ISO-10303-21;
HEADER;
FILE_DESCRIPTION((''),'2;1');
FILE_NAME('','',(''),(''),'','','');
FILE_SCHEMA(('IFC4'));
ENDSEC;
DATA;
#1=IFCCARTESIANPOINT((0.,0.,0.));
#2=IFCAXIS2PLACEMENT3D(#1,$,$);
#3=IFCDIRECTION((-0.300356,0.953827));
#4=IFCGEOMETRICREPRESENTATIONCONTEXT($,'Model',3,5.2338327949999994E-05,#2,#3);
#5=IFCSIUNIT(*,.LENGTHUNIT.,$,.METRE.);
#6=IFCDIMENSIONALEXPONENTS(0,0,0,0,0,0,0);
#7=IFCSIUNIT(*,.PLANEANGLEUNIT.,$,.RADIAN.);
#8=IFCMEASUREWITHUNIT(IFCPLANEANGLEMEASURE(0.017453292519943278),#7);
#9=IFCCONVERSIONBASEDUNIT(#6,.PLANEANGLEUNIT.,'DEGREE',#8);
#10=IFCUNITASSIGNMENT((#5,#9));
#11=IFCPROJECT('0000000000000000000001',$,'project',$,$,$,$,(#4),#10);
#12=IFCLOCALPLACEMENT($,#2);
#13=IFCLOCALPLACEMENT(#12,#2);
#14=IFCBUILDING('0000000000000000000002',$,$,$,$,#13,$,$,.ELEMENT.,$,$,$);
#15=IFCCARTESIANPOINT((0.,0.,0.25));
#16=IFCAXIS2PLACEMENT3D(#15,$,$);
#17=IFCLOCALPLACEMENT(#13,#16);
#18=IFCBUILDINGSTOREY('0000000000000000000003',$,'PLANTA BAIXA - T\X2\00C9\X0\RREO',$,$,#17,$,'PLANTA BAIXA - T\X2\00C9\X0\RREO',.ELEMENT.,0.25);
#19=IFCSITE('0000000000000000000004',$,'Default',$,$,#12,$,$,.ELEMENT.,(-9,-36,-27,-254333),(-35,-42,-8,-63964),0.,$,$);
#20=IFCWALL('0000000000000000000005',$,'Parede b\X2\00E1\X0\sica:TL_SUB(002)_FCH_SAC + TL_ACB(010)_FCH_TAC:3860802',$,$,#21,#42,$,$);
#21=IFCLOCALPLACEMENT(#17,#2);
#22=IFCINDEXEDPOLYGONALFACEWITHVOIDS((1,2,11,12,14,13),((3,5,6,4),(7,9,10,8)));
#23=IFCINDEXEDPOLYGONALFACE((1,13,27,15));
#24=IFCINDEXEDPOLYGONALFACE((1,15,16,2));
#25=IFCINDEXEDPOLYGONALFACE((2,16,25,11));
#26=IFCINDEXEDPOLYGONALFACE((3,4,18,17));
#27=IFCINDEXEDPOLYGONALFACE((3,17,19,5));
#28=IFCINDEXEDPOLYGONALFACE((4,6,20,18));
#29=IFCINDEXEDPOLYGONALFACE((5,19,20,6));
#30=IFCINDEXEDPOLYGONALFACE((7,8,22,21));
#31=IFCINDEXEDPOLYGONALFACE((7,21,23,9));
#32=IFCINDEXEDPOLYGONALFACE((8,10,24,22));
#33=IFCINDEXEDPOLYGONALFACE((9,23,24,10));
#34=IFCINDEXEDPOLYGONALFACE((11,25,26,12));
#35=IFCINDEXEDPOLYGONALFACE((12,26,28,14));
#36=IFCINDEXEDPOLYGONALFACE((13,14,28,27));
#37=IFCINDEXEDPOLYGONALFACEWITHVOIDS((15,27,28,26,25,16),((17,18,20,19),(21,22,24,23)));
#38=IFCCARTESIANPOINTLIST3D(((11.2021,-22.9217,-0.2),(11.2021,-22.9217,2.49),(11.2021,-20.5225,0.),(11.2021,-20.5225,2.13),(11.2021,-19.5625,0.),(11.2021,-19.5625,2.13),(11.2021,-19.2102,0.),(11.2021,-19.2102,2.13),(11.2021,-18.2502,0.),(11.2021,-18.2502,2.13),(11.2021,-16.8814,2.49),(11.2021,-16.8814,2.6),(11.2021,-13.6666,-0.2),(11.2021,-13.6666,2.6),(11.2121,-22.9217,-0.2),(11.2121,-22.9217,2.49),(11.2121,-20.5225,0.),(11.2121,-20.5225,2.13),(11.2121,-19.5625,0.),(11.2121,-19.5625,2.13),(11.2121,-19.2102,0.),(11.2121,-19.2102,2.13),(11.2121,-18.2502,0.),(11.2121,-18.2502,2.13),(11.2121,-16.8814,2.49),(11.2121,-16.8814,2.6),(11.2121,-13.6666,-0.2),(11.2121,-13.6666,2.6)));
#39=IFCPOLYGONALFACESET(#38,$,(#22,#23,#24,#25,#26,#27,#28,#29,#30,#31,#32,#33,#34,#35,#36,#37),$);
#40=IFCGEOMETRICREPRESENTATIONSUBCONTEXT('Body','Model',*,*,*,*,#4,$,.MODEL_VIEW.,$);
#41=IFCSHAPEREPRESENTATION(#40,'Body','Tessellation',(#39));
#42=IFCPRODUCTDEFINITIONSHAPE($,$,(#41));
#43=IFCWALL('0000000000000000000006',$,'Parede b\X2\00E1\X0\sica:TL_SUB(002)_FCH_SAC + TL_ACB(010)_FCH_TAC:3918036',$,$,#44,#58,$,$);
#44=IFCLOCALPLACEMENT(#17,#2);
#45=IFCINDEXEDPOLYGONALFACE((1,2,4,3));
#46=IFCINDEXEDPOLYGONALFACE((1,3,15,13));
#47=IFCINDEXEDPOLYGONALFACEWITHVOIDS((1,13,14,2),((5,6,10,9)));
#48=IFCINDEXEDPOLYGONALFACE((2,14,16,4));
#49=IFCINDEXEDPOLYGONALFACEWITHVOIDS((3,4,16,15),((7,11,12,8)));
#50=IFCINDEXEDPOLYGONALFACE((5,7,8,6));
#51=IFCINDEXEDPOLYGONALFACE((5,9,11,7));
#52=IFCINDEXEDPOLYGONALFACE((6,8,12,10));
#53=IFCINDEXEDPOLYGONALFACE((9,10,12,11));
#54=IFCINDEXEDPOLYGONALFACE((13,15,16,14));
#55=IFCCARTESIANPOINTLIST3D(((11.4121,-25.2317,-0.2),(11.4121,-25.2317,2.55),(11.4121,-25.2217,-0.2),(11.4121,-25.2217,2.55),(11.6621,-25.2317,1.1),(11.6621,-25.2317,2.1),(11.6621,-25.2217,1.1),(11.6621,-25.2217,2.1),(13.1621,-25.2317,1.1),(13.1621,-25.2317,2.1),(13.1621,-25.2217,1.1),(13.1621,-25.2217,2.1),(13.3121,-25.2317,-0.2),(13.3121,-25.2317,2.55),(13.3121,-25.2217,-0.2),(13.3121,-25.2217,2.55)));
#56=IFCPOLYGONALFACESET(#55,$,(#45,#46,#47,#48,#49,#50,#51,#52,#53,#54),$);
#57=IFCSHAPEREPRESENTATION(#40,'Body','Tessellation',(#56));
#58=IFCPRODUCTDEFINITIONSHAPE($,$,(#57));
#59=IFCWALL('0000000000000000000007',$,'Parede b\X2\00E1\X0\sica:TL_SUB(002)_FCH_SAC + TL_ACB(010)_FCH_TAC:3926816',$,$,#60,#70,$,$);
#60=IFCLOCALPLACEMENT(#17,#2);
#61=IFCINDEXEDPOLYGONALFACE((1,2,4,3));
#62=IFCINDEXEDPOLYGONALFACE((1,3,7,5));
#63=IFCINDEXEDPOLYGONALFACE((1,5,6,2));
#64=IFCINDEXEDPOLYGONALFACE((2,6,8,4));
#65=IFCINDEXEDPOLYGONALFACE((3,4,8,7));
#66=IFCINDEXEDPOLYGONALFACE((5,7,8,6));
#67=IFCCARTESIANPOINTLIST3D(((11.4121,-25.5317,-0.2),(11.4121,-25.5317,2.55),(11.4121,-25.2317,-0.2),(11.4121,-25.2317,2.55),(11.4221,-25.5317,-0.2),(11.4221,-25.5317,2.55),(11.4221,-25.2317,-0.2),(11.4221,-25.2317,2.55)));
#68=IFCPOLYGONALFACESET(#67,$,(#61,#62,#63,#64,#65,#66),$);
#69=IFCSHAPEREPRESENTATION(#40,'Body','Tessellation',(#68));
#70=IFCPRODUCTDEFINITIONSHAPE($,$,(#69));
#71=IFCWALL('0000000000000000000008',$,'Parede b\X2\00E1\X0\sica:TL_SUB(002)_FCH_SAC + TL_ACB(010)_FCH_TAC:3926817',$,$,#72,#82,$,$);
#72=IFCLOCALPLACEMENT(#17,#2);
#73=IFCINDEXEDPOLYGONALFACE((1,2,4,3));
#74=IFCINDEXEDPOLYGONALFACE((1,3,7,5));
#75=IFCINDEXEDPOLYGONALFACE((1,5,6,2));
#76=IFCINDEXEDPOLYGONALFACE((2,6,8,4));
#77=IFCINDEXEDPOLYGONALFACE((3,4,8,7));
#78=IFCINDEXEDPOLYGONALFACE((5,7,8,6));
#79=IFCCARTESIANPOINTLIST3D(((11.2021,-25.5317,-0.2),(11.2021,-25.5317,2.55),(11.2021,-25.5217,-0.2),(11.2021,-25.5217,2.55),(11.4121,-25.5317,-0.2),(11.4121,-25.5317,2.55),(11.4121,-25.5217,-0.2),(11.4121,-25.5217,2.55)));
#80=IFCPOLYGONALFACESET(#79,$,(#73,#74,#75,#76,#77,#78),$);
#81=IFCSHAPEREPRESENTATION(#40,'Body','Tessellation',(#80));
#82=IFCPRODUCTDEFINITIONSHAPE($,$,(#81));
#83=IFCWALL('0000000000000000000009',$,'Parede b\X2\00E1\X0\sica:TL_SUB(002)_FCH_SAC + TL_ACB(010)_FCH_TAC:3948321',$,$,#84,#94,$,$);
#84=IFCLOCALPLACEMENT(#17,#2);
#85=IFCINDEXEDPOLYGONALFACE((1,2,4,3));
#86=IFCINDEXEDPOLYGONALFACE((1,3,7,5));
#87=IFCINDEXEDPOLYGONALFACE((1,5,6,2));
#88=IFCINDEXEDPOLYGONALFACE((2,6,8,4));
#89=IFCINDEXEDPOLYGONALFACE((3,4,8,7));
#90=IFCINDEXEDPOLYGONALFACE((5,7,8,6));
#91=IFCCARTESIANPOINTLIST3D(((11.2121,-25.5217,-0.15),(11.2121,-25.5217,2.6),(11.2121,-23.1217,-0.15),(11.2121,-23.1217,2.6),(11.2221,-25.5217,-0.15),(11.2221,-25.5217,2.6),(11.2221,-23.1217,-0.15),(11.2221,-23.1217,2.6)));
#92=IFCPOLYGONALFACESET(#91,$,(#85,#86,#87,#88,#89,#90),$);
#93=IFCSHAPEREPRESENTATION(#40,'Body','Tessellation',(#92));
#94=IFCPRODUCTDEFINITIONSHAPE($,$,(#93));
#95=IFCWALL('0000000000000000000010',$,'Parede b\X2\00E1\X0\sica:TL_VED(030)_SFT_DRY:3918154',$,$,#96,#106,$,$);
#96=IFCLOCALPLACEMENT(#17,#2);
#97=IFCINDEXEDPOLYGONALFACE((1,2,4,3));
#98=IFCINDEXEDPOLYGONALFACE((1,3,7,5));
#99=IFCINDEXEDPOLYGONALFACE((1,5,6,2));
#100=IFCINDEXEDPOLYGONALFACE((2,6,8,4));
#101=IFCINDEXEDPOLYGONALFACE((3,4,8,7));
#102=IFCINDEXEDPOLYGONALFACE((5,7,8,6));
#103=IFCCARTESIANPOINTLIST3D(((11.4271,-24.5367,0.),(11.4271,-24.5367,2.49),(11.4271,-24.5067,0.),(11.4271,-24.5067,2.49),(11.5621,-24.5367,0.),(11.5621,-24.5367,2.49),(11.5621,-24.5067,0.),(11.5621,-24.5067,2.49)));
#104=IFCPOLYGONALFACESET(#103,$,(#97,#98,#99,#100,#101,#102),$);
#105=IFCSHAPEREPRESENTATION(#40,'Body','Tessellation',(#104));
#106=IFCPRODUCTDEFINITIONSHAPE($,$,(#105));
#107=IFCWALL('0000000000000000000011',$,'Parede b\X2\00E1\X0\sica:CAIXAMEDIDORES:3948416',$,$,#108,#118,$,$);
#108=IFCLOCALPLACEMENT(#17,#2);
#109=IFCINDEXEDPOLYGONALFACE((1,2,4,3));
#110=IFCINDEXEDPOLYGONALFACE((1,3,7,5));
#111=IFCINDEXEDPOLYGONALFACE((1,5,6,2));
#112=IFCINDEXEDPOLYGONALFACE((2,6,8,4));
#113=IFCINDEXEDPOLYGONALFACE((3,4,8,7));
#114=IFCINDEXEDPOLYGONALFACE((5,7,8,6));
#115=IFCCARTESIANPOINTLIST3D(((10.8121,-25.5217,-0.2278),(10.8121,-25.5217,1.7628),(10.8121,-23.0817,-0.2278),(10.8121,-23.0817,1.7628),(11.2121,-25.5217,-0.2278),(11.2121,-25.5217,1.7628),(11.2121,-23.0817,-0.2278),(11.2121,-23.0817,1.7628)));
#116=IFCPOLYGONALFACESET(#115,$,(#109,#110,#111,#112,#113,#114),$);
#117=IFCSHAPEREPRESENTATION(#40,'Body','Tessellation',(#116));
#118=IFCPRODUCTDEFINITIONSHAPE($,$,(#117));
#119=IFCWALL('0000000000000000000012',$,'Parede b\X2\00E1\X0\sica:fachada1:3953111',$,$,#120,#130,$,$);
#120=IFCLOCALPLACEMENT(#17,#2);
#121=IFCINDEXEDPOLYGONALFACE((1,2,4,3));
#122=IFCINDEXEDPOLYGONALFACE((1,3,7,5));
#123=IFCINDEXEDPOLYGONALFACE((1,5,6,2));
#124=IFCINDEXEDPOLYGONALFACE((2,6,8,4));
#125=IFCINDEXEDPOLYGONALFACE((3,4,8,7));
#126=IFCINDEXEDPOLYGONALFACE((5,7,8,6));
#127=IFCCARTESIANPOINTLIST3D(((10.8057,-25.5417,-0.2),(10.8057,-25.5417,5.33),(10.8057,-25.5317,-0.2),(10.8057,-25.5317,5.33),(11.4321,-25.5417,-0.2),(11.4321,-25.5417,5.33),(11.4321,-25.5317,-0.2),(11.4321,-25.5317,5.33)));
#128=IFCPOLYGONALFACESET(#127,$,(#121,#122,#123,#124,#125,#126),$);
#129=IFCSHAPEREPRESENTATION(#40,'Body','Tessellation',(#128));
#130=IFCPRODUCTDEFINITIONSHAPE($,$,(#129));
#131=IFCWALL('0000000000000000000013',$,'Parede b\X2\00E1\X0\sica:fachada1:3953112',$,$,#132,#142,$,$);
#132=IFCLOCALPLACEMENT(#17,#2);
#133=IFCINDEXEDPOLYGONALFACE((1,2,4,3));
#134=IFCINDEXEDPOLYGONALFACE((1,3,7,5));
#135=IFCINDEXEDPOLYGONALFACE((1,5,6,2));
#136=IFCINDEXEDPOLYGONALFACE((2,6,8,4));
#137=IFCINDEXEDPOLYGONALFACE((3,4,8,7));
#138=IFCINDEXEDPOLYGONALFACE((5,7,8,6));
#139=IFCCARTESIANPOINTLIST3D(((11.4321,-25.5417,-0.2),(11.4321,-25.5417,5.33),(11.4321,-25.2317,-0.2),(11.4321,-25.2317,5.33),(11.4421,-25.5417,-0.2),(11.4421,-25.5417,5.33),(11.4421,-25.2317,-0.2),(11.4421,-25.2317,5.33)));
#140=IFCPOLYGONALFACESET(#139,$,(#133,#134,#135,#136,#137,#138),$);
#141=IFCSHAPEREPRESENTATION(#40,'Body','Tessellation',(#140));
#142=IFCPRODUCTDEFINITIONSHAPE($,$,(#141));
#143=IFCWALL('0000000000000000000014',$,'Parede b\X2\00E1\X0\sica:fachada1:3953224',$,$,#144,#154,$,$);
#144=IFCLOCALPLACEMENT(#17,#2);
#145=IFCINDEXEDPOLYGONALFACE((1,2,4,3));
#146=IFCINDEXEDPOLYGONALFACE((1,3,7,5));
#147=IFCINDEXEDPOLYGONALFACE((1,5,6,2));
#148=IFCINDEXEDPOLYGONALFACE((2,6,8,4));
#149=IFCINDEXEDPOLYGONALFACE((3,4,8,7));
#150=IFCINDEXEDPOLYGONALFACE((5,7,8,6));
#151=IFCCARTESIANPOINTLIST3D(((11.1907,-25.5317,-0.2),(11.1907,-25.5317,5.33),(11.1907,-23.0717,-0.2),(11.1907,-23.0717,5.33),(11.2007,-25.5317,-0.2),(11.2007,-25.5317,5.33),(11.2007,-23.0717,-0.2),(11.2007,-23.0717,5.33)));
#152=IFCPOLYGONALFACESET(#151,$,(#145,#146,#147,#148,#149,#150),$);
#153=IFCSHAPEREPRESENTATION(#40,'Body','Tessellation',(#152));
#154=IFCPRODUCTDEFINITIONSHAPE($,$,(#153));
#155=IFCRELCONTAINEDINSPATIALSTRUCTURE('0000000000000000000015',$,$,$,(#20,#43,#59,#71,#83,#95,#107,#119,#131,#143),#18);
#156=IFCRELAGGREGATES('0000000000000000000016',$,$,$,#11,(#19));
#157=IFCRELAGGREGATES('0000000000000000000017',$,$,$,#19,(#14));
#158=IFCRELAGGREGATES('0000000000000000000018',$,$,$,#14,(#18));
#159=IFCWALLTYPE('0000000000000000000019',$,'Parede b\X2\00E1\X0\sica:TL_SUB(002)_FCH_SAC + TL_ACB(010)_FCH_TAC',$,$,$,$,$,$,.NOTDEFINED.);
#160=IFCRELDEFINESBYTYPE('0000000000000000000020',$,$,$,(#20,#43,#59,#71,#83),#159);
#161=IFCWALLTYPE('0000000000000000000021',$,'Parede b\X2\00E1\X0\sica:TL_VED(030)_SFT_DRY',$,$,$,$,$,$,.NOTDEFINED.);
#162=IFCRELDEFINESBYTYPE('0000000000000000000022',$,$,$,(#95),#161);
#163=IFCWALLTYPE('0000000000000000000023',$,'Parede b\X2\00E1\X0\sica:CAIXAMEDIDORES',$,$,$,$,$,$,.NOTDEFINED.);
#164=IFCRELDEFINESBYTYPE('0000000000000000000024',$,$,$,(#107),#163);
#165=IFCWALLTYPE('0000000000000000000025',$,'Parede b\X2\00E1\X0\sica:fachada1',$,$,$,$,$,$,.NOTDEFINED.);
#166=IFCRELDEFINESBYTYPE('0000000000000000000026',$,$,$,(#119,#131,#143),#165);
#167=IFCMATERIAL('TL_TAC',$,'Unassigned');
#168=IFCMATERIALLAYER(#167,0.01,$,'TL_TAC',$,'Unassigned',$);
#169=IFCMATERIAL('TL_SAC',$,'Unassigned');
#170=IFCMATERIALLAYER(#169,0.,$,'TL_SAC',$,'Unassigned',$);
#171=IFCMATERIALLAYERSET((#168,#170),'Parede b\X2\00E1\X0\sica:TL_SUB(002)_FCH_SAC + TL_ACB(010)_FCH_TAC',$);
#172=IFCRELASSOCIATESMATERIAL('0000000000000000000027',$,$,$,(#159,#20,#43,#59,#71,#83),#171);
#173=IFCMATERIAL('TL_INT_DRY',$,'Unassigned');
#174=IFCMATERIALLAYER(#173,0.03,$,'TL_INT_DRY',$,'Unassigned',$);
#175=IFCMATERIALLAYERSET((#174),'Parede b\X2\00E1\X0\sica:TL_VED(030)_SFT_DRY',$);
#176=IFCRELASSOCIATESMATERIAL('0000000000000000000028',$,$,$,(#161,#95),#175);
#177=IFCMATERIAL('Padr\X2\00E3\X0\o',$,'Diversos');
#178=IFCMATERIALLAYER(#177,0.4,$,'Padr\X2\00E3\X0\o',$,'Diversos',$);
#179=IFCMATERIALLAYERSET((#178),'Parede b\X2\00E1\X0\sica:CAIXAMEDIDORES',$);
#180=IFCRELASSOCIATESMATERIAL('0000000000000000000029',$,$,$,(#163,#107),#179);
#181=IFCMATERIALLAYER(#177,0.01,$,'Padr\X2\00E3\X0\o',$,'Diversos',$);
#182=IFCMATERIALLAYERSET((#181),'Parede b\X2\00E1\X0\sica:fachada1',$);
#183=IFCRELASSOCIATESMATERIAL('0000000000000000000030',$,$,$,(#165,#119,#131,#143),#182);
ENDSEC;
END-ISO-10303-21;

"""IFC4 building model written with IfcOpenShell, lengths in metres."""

from ifc_helpers import new_model, entity, si_unit, converted_unit, direction, frame, frame_2d, origin, place, context, subcontext, project, spatial, polyline, rectangle, extrude, clip, bounded_halfspace, material, layer, layer_set, layer_usage, type_object, element, save


model = new_model("IFC4")

# Units and contexts
model_context = context("Model", 3, precision=5.2338327949999994e-05, world=origin(), true_north=direction((-0.300356, 0.953827)))
body_context = subcontext(model_context, "Body", "Model", "MODEL_VIEW")
ifc_project = project(units=[si_unit("LENGTHUNIT", "METRE"), converted_unit("PLANEANGLEUNIT", "DEGREE", entity("IfcPlaneAngleMeasure", 0.017453292519943278), si_unit("PLANEANGLEUNIT", "RADIAN"), dimensions=[0, 0, 0, 0, 0, 0, 0])], contexts=[model_context])

# Site, building, storey
site_placement = place(None, origin())
site = spatial("IfcSite", under=ifc_project, at=site_placement, Name="Default", CompositionType="ELEMENT", RefLatitude=(-9, -36, -27, -254333), RefLongitude=(-35, -42, -8, -63964), RefElevation=0.0)
building_placement = place(site_placement, origin())
building = spatial("IfcBuilding", under=site, at=building_placement, CompositionType="ELEMENT")
storey_placement = place(building_placement, frame((0.0, 0.0, 0.25)))
storey = spatial("IfcBuildingStorey", under=building, at=storey_placement, Name="PLANTA BAIXA - TÉRREO", LongName="PLANTA BAIXA - TÉRREO", CompositionType="ELEMENT", Elevation=0.25)

# Shared definitions
ifc_material_1 = material(Name="TL_SAC", Category="Unassigned")

# Shared definitions
ifc_material_2 = material(Name="TL_TAC", Category="Unassigned")
ifc_layer_1 = layer(ifc_material_2, 0.01, Name="TL_TAC", Category="Unassigned")
ifc_layer_2 = layer(ifc_material_1, 0.0, Name="TL_SAC", Category="Unassigned")
ifc_layer_set_1 = layer_set([ifc_layer_1, ifc_layer_2], Name="Parede básica:TL_SUB(002)_FCH_SAC + TL_ACB(010)_FCH_TAC")
wall_type_1 = type_object("IfcWallType", Name="Parede básica:TL_SUB(002)_FCH_SAC + TL_ACB(010)_FCH_TAC", PredefinedType="NOTDEFINED", material=ifc_layer_set_1)

# Wall, openings
ifc_layer_usage_1 = layer_usage(ifc_layer_set_1, "AXIS2", "POSITIVE", -0.005)
wall_1_placement = place(storey_placement, frame((11.2071, -22.9217, -0.2), z_axis=(0.0, 0.0, 1.0), x_axis=(0.0, 1.0, 0.0)))
wall_1 = element("IfcWall", 1, at=wall_1_placement, inside=storey, type_object=wall_type_1, material=ifc_layer_usage_1, Name="Parede básica:TL_SUB(002)_FCH_SAC + TL_ACB(010)_FCH_TAC:3860802", context=body_context, shape_type="Clipping", body=[
    clip(extrude(rectangle(XDim=9.2551, YDim=0.01, at=frame_2d((4.6276, 0.0), x_axis=(-1.0, 0.0))), origin(), (0.0, 0.0, 1.0), 2.8), bounded_halfspace(frame((0.0, -0.005, 2.69), z_axis=(0.0, 0.0, -1.0), x_axis=(-1.0, 0.0, 0.0)), True, frame((0.0, -0.005, 2.69)), polyline([(0.0, 0.0), (3.5354, 0.0), (6.0403, 0.0), (6.0403, 0.01), (0.01, 0.01), (0.0, 0.01), (0.0, 0.0)]))),
])
opening_1_placement = place(wall_1_placement, frame((22.9217, 11.2071, 0.2)))
element("IfcOpeningElement", 2, at=opening_1_placement, cuts=wall_1, PredefinedType="OPENING", context=body_context, shape_type="SweptSolid", body=[
    extrude(rectangle(XDim=2.13, YDim=0.96, at=frame_2d((0.0, 0.0), x_axis=(0.0, 1.0))), frame((-18.7302, -12.9361, 1.065), z_axis=(0.0, 1.0, 0.0), x_axis=(-1.0, 0.0, 0.0)), (0.0, 0.0, 1.0), 3.048),
])
opening_2_placement = place(wall_1_placement, frame((22.9217, 11.2071, 0.2)))
element("IfcOpeningElement", 3, at=opening_2_placement, cuts=wall_1, PredefinedType="OPENING", context=body_context, shape_type="SweptSolid", body=[
    extrude(rectangle(XDim=2.13, YDim=0.96, at=frame_2d((0.0, 0.0), x_axis=(1.0, 0.0))), frame((-20.0425, -12.9361, 1.065), z_axis=(0.0, 1.0, 0.0), x_axis=(0.0, 0.0, 1.0)), (0.0, 0.0, 1.0), 3.048),
])

# Wall, opening
ifc_layer_usage_2 = layer_usage(ifc_layer_set_1, "AXIS2", "NEGATIVE", 0.005)
wall_2_placement = place(storey_placement, frame((11.4121, -25.2267, -0.2)))
wall_2 = element("IfcWall", 4, at=wall_2_placement, inside=storey, type_object=wall_type_1, material=ifc_layer_usage_2, Name="Parede básica:TL_SUB(002)_FCH_SAC + TL_ACB(010)_FCH_TAC:3918036", context=body_context, shape_type="SweptSolid", body=[
    extrude(rectangle(XDim=1.9, YDim=0.01, at=frame_2d((0.95, 0.0), x_axis=(-1.0, 0.0))), origin(), (0.0, 0.0, 1.0), 2.75),
])
opening_3_placement = place(wall_2_placement, frame((-11.4121, 25.2267, 1.3)))
element("IfcOpeningElement", 5, at=opening_3_placement, cuts=wall_2, PredefinedType="OPENING", context=body_context, shape_type="SweptSolid", body=[
    extrude(rectangle(XDim=1.0, YDim=1.5, at=frame_2d((0.0, 0.0), x_axis=(0.0, 1.0))), frame((12.4121, -26.6457, 0.5), z_axis=(0.0, 1.0, 0.0), x_axis=(1.0, 0.0, 0.0)), (0.0, 0.0, 1.0), 3.048),
])

# Walls
ifc_layer_usage_3 = layer_usage(ifc_layer_set_1, "AXIS2", "POSITIVE", -0.005)
wall_3_placement = place(storey_placement, frame((11.4171, -25.2317, -0.2), z_axis=(0.0, 0.0, 1.0), x_axis=(0.0, -1.0, 0.0)))
element("IfcWall", 6, at=wall_3_placement, inside=storey, type_object=wall_type_1, material=ifc_layer_usage_3, Name="Parede básica:TL_SUB(002)_FCH_SAC + TL_ACB(010)_FCH_TAC:3926816", context=body_context, shape_type="SweptSolid", body=[
    extrude(rectangle(XDim=0.3, YDim=0.01, at=frame_2d((0.15, 0.0), x_axis=(-1.0, 0.0))), origin(), (0.0, 0.0, 1.0), 2.75),
])
ifc_layer_usage_4 = layer_usage(ifc_layer_set_1, "AXIS2", "POSITIVE", -0.005)
wall_4_placement = place(storey_placement, frame((11.4121, -25.5267, -0.2), z_axis=(0.0, 0.0, 1.0), x_axis=(-1.0, 0.0, 0.0)))
element("IfcWall", 7, at=wall_4_placement, inside=storey, type_object=wall_type_1, material=ifc_layer_usage_4, Name="Parede básica:TL_SUB(002)_FCH_SAC + TL_ACB(010)_FCH_TAC:3926817", context=body_context, shape_type="SweptSolid", body=[
    extrude(rectangle(XDim=0.21, YDim=0.01, at=frame_2d((0.105, 0.0), x_axis=(-1.0, 0.0))), origin(), (0.0, 0.0, 1.0), 2.75),
])
ifc_layer_usage_5 = layer_usage(ifc_layer_set_1, "AXIS2", "NEGATIVE", 0.005)
wall_5_placement = place(storey_placement, frame((11.2171, -25.5217, -0.15), z_axis=(0.0, 0.0, 1.0), x_axis=(0.0, 1.0, 0.0)))
element("IfcWall", 8, at=wall_5_placement, inside=storey, type_object=wall_type_1, material=ifc_layer_usage_5, Name="Parede básica:TL_SUB(002)_FCH_SAC + TL_ACB(010)_FCH_TAC:3948321", context=body_context, shape_type="SweptSolid", body=[
    extrude(rectangle(XDim=2.4, YDim=0.01, at=frame_2d((1.2, 0.0), x_axis=(-1.0, 0.0))), origin(), (0.0, 0.0, 1.0), 2.75),
])
ifc_material_3 = material(Name="TL_INT_DRY", Category="Unassigned")
ifc_layer_3 = layer(ifc_material_3, 0.03, Name="TL_INT_DRY", Category="Unassigned")
ifc_layer_set_2 = layer_set([ifc_layer_3], Name="Parede básica:TL_VED(030)_SFT_DRY")
ifc_layer_usage_6 = layer_usage(ifc_layer_set_2, "AXIS2", "POSITIVE", -0.015)
wall_type_2 = type_object("IfcWallType", Name="Parede básica:TL_VED(030)_SFT_DRY", PredefinedType="NOTDEFINED", material=ifc_layer_set_2)
wall_6_placement = place(storey_placement, frame((11.5621, -24.5217, 0.0), z_axis=(0.0, 0.0, 1.0), x_axis=(-1.0, 0.0, 0.0)))
element("IfcWall", 9, at=wall_6_placement, inside=storey, type_object=wall_type_2, material=ifc_layer_usage_6, Name="Parede básica:TL_VED(030)_SFT_DRY:3918154", context=body_context, shape_type="SweptSolid", body=[
    extrude(rectangle(XDim=0.135, YDim=0.03, at=frame_2d((0.0675, 0.0), x_axis=(-1.0, 0.0))), origin(), (0.0, 0.0, 1.0), 2.49),
])
ifc_material_4 = material(Name="Padrão", Category="Diversos")
ifc_layer_4 = layer(ifc_material_4, 0.4, Name="Padrão", Category="Diversos")
ifc_layer_set_3 = layer_set([ifc_layer_4], Name="Parede básica:CAIXAMEDIDORES")
ifc_layer_usage_7 = layer_usage(ifc_layer_set_3, "AXIS2", "NEGATIVE", 0.2)
wall_type_3 = type_object("IfcWallType", Name="Parede básica:CAIXAMEDIDORES", PredefinedType="NOTDEFINED", material=ifc_layer_set_3)
wall_7_placement = place(storey_placement, frame((11.0121, -23.0817, -0.2278), z_axis=(0.0, 0.0, 1.0), x_axis=(0.0, -1.0, 0.0)))
element("IfcWall", 10, at=wall_7_placement, inside=storey, type_object=wall_type_3, material=ifc_layer_usage_7, Name="Parede básica:CAIXAMEDIDORES:3948416", context=body_context, shape_type="SweptSolid", body=[
    extrude(rectangle(XDim=2.44, YDim=0.4, at=frame_2d((1.22, 0.0), x_axis=(-1.0, 0.0))), origin(), (0.0, 0.0, 1.0), 1.9905),
])
ifc_layer_5 = layer(ifc_material_4, 0.01, Name="Padrão", Category="Diversos")
ifc_layer_set_4 = layer_set([ifc_layer_5], Name="Parede básica:fachada1")
ifc_layer_usage_8 = layer_usage(ifc_layer_set_4, "AXIS2", "POSITIVE", -0.005)
wall_type_4 = type_object("IfcWallType", Name="Parede básica:fachada1", PredefinedType="NOTDEFINED", material=ifc_layer_set_4)
wall_8_placement = place(storey_placement, frame((11.4321, -25.5367, -0.2), z_axis=(0.0, 0.0, 1.0), x_axis=(-1.0, 0.0, 0.0)))
element("IfcWall", 11, at=wall_8_placement, inside=storey, type_object=wall_type_4, material=ifc_layer_usage_8, Name="Parede básica:fachada1:3953111", context=body_context, shape_type="SweptSolid", body=[
    extrude(rectangle(XDim=0.6264, YDim=0.01, at=frame_2d((0.3132, 0.0), x_axis=(-1.0, 0.0))), origin(), (0.0, 0.0, 1.0), 5.53),
])
ifc_layer_usage_9 = layer_usage(ifc_layer_set_4, "AXIS2", "POSITIVE", -0.005)
wall_9_placement = place(storey_placement, frame((11.4371, -25.2317, -0.2), z_axis=(0.0, 0.0, 1.0), x_axis=(0.0, -1.0, 0.0)))
element("IfcWall", 12, at=wall_9_placement, inside=storey, type_object=wall_type_4, material=ifc_layer_usage_9, Name="Parede básica:fachada1:3953112", context=body_context, shape_type="SweptSolid", body=[
    extrude(rectangle(XDim=0.31, YDim=0.01, at=frame_2d((0.155, 0.0), x_axis=(-1.0, 0.0))), origin(), (0.0, 0.0, 1.0), 5.53),
])
ifc_layer_usage_10 = layer_usage(ifc_layer_set_4, "AXIS2", "POSITIVE", -0.005)
wall_10_placement = place(storey_placement, frame((11.1957, -25.5317, -0.2), z_axis=(0.0, 0.0, 1.0), x_axis=(0.0, 1.0, 0.0)))
element("IfcWall", 13, at=wall_10_placement, inside=storey, type_object=wall_type_4, material=ifc_layer_usage_10, Name="Parede básica:fachada1:3953224", context=body_context, shape_type="SweptSolid", body=[
    extrude(rectangle(XDim=2.46, YDim=0.01, at=frame_2d((1.23, 0.0), x_axis=(-1.0, 0.0))), origin(), (0.0, 0.0, 1.0), 5.53),
])

save(model, "model.ifc")
